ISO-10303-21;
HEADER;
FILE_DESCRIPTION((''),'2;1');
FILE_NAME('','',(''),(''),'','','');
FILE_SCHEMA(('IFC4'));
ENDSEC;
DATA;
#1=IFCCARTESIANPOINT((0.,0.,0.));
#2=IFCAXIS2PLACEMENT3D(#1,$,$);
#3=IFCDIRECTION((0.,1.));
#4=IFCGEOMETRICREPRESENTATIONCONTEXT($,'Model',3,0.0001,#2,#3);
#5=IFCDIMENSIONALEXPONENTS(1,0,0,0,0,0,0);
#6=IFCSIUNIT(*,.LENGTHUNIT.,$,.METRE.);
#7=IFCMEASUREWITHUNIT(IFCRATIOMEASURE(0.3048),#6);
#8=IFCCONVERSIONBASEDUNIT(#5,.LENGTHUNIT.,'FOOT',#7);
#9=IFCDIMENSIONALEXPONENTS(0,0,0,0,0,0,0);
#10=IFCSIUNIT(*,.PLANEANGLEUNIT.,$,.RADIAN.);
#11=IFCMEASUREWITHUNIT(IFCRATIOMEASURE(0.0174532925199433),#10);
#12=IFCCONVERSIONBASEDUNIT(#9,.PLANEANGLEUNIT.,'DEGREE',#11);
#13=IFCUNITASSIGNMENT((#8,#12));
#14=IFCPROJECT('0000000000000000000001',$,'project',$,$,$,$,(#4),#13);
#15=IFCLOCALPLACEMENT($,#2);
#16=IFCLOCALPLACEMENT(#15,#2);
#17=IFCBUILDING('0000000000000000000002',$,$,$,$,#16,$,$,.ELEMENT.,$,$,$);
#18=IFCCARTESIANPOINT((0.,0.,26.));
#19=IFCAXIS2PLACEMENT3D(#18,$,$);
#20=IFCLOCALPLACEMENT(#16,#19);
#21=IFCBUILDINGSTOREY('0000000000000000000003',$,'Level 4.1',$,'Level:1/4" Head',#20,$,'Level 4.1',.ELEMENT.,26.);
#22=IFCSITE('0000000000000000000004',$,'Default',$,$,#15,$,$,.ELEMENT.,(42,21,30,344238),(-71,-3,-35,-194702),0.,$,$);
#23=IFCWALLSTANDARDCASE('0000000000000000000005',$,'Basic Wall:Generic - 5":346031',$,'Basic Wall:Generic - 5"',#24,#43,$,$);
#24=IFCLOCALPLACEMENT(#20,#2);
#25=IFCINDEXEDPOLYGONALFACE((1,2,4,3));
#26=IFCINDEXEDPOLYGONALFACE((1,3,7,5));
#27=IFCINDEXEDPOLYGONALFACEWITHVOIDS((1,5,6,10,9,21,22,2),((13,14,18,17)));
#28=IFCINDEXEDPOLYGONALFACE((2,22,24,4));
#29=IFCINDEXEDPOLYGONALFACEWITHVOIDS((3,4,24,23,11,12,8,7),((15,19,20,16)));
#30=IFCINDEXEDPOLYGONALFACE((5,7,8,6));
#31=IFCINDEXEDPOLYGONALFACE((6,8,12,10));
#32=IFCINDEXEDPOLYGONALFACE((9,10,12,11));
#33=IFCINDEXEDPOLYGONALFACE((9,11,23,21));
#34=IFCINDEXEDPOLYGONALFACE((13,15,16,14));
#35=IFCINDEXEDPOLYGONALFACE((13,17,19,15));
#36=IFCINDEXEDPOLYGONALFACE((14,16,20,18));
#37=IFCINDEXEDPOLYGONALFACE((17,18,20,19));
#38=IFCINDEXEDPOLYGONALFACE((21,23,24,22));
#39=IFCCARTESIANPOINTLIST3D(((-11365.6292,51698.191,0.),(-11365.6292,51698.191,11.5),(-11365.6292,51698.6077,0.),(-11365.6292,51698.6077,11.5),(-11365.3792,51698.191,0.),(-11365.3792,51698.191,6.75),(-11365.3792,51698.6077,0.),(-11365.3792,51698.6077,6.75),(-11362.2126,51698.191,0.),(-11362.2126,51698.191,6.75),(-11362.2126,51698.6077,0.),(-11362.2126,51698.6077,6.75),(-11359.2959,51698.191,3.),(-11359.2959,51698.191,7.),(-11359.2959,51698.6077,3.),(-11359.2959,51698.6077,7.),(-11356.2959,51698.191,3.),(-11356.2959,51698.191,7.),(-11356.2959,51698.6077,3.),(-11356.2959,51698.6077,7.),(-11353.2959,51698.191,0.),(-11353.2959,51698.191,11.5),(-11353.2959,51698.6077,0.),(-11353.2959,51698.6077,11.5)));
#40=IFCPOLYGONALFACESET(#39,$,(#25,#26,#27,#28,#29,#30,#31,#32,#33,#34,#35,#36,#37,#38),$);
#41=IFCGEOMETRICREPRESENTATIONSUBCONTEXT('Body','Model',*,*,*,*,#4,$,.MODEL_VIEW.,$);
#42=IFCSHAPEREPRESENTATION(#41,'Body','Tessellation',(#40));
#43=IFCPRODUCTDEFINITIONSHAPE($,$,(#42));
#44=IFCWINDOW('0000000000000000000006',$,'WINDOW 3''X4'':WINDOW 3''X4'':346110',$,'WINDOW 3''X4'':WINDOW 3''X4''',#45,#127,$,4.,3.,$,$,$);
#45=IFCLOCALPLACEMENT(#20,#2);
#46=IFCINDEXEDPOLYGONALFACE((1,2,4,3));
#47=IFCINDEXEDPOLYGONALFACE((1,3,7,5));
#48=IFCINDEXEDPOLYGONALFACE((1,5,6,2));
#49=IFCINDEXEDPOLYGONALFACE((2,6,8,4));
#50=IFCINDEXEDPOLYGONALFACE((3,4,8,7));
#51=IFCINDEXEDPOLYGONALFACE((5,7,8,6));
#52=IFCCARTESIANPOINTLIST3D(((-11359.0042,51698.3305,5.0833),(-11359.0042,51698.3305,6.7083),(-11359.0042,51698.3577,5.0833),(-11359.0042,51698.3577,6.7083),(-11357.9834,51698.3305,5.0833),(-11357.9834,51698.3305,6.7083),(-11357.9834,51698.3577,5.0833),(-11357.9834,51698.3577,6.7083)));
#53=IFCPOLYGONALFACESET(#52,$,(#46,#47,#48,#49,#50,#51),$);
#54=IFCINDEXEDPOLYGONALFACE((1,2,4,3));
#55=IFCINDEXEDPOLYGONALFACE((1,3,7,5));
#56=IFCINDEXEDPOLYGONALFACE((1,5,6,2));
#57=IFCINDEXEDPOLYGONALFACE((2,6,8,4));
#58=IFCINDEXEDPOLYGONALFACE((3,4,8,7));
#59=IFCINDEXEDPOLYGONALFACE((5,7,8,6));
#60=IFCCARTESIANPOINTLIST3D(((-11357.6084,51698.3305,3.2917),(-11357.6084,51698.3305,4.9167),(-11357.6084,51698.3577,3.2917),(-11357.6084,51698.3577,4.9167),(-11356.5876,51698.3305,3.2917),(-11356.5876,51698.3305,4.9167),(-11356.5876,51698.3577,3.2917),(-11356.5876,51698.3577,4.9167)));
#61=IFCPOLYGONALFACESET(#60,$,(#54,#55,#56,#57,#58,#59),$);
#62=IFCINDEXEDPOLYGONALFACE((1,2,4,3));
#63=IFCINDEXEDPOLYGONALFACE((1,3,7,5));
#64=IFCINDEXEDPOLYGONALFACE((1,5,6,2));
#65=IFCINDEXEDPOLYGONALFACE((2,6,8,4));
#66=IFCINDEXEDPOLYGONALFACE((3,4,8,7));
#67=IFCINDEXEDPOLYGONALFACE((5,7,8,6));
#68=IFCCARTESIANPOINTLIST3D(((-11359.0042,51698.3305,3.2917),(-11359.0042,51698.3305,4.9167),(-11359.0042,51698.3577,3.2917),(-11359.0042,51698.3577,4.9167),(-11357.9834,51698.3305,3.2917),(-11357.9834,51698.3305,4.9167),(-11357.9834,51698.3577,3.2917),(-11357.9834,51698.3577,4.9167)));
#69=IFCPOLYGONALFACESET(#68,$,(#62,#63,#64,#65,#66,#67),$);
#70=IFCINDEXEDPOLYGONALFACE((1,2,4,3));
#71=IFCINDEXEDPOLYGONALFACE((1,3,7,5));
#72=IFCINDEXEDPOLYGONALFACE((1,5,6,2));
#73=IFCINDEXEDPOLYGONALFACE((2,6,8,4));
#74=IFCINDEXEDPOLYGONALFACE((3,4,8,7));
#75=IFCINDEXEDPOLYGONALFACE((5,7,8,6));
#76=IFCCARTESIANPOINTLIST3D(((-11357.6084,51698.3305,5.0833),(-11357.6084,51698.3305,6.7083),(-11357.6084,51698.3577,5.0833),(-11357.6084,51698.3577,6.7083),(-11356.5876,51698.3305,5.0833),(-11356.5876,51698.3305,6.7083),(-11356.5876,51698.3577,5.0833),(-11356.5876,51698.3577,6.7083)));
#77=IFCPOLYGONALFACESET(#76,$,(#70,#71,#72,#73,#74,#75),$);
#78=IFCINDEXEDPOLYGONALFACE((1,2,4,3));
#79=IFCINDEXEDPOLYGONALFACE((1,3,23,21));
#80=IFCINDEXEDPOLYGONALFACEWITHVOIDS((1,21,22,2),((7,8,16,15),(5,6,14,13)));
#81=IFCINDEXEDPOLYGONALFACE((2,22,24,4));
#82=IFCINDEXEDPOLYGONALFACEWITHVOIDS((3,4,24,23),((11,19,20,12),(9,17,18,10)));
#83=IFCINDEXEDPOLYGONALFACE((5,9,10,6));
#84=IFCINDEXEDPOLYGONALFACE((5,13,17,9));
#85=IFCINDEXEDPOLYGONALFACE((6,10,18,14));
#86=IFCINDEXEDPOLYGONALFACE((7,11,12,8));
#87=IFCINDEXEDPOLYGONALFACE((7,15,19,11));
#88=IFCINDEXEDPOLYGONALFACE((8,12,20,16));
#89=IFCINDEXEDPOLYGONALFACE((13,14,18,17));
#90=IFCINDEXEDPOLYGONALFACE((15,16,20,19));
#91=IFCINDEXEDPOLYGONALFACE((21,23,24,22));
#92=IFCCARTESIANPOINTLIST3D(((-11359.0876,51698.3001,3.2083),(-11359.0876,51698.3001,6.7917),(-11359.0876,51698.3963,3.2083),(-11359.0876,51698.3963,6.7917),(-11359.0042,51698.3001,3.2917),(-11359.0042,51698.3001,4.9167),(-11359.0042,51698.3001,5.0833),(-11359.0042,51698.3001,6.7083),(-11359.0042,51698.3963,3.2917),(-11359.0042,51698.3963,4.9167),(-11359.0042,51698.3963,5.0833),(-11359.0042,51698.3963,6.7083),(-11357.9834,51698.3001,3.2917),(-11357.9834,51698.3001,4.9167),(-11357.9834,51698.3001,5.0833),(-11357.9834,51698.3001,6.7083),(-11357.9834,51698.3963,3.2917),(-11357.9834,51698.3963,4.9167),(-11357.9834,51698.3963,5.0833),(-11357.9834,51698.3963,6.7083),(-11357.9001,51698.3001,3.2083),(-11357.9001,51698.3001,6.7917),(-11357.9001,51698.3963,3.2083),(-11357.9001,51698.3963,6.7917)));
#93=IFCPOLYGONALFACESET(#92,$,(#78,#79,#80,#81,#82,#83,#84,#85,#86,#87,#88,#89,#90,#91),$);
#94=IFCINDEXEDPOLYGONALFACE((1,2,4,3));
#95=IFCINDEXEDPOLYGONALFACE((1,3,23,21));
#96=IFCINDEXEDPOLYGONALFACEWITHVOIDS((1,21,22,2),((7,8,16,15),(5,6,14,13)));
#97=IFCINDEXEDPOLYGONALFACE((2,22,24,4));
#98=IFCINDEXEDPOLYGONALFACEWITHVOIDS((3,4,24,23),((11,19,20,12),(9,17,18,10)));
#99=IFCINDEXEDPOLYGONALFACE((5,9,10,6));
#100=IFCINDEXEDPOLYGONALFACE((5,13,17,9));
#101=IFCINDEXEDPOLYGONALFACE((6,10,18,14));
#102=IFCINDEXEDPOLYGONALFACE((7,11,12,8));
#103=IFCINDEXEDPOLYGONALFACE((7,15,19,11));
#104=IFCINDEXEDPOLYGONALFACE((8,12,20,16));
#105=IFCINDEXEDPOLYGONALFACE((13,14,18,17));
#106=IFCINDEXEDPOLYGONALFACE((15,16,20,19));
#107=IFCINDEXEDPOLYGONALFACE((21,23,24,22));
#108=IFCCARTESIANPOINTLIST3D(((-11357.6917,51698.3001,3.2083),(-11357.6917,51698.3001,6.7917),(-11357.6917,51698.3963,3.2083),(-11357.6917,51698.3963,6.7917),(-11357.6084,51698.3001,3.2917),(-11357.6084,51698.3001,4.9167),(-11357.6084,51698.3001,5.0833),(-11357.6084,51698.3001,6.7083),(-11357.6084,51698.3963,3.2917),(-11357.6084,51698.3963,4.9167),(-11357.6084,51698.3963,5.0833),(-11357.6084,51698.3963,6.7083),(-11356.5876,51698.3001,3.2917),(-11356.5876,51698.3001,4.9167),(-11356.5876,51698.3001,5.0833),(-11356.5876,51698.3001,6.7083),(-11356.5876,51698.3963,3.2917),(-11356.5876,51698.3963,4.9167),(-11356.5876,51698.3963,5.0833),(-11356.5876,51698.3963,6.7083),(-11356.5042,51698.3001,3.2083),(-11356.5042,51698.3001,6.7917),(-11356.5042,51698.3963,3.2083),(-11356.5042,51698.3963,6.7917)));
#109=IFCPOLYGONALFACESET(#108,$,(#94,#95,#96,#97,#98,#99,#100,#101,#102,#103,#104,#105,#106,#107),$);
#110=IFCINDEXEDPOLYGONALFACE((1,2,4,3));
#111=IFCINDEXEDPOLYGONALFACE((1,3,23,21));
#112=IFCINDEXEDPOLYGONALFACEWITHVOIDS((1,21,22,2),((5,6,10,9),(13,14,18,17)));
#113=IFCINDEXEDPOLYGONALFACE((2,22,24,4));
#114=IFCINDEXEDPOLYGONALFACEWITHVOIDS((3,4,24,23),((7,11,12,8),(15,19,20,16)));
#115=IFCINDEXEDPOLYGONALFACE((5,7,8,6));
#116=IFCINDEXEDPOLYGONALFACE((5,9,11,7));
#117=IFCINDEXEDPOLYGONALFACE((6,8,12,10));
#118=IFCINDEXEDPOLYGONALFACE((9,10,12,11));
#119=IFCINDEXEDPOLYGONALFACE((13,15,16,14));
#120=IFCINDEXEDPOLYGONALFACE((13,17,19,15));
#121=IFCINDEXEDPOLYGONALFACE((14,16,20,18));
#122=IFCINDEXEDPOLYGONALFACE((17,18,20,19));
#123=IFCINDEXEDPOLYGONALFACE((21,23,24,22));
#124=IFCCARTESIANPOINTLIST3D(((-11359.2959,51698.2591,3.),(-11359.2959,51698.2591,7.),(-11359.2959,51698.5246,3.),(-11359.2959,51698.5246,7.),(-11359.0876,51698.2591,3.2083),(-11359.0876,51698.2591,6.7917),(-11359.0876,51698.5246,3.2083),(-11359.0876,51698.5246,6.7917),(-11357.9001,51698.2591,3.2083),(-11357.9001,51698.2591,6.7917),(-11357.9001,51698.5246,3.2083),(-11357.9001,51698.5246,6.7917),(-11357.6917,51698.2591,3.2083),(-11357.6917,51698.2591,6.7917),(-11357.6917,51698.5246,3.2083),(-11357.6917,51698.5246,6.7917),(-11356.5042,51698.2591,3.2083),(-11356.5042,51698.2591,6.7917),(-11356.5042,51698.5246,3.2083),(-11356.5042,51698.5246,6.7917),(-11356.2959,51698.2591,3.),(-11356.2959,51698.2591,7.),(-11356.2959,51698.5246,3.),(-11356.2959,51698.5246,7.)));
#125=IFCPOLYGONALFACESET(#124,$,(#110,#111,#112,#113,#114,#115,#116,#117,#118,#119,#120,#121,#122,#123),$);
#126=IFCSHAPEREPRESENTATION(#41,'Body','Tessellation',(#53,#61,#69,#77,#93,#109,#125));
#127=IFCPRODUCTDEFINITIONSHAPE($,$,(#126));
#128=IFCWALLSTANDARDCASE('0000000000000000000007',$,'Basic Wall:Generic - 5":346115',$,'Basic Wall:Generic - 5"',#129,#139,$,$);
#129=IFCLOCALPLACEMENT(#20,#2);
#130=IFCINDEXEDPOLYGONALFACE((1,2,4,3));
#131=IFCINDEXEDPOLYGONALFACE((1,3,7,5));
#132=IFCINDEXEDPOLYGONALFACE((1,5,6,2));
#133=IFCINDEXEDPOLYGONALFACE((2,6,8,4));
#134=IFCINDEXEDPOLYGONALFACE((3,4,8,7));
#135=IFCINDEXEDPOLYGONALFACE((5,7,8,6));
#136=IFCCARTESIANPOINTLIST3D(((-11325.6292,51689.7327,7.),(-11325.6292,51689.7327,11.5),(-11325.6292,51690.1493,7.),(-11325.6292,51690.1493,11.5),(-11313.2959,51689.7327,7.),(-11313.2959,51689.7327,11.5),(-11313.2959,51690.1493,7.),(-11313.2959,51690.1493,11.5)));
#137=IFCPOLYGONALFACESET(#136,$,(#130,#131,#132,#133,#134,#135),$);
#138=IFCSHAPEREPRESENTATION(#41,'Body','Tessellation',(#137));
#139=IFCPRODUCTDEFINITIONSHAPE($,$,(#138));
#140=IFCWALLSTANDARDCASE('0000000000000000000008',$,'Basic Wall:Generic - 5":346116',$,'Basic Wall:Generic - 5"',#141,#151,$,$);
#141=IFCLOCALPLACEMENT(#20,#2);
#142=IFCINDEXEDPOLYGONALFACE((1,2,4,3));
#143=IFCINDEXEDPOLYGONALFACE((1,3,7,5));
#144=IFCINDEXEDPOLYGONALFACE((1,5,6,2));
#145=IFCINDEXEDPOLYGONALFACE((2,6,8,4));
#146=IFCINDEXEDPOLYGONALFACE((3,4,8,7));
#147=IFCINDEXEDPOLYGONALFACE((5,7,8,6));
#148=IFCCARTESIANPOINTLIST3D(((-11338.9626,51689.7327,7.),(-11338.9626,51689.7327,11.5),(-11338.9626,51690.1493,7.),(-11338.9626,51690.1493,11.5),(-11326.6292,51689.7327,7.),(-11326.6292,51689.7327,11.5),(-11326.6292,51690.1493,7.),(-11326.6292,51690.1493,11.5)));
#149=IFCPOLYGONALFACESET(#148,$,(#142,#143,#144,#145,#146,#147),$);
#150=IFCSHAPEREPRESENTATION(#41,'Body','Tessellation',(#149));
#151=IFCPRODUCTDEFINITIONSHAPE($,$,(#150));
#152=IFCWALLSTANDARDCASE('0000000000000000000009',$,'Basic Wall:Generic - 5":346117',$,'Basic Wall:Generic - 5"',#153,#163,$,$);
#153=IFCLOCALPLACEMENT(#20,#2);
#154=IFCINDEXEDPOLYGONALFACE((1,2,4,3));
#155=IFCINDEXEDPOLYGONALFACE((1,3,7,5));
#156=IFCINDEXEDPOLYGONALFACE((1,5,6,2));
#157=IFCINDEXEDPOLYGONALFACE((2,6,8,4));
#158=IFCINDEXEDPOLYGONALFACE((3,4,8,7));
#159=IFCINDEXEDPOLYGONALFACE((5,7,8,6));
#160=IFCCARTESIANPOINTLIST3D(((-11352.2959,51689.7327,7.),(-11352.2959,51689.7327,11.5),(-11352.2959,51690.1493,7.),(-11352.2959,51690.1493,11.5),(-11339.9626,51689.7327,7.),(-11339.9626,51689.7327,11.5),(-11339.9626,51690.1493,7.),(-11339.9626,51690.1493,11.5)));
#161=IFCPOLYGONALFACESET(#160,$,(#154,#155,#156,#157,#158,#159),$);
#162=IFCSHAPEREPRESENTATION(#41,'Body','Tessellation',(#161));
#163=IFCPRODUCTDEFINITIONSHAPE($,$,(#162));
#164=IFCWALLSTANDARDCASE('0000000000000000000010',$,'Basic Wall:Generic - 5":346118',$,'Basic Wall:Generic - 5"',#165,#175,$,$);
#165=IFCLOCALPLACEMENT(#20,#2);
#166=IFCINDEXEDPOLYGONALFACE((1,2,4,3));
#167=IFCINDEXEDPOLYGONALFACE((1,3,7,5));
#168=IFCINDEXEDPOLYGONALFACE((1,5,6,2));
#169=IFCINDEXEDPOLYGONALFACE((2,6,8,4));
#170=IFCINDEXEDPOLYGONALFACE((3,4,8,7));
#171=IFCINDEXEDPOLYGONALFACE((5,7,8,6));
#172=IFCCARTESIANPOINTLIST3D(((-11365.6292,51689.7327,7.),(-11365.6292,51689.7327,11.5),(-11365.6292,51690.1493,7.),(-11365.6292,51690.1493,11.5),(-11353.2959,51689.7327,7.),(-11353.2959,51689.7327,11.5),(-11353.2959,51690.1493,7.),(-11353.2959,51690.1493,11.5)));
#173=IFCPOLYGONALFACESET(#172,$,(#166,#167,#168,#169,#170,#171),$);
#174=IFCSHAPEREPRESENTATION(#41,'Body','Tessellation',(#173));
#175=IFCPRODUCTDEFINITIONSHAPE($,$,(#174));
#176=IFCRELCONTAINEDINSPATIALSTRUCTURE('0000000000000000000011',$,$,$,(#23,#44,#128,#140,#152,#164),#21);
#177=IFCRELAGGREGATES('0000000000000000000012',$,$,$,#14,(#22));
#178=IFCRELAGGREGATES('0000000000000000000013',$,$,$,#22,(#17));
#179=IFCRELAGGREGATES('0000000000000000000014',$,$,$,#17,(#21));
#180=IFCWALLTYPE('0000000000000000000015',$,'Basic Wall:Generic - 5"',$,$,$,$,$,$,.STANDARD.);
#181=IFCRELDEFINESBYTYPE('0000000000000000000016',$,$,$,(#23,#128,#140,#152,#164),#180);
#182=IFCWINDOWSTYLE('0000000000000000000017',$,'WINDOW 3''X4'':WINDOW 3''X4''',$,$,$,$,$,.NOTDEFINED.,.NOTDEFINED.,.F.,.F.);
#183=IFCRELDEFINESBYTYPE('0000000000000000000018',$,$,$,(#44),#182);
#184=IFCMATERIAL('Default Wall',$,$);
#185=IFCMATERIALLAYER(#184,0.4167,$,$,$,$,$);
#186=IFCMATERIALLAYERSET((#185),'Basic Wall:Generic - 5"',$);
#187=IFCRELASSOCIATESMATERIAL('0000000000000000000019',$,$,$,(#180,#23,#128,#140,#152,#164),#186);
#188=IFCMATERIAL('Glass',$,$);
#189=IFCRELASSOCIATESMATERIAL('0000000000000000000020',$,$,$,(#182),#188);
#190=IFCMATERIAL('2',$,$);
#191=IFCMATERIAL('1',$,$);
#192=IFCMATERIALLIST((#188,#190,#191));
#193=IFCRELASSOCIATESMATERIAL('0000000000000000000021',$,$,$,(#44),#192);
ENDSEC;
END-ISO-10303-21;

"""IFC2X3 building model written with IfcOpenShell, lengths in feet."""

from ifc_helpers import new_model, entity, si_unit, converted_unit, direction, frame, frame_2d, origin, origin_2d_with_axis, place, context, subcontext, project, spatial, polyline, rectangle, outline, extrude, source, transform, mapped, material, material_list, layer, layer_set, layer_usage, type_object, type_shapes, element, fill, save


model = new_model("IFC2X3")

# Units and contexts
model_context = context("Model", 3, precision=0.0001, world=origin(), true_north=direction((0.0, 1.0)))
body_context = subcontext(model_context, "Body", "Model", "MODEL_VIEW")
ifc_project = project(units=[converted_unit("LENGTHUNIT", "FOOT", entity("IfcRatioMeasure", 0.3048), si_unit("LENGTHUNIT", "METRE"), dimensions=[1, 0, 0, 0, 0, 0, 0]), converted_unit("PLANEANGLEUNIT", "DEGREE", entity("IfcRatioMeasure", 0.0174532925199433), si_unit("PLANEANGLEUNIT", "RADIAN"), dimensions=[0, 0, 0, 0, 0, 0, 0])], contexts=[model_context])

# Site, building, storey
site_placement = place(None, origin())
site = spatial("IfcSite", under=ifc_project, at=site_placement, Name="Default", CompositionType="ELEMENT", RefLatitude=(42, 21, 30, 344238), RefLongitude=(-71, -3, -35, -194702), RefElevation=0.0)
building_placement = place(site_placement, origin())
building = spatial("IfcBuilding", under=site, at=building_placement, CompositionType="ELEMENT")
storey_placement = place(building_placement, frame((0.0, 0.0, 26.0)))
storey = spatial("IfcBuildingStorey", under=building, at=storey_placement, Name="Level 4.1", ObjectType="Level:1/4\" Head", LongName="Level 4.1", CompositionType="ELEMENT", Elevation=26.0)

# Wall, openings, window
ifc_material_1 = material(Name="Default Wall")
ifc_layer = layer(ifc_material_1, 0.4167)
ifc_layer_set = layer_set([ifc_layer], Name="Basic Wall:Generic - 5\"")
ifc_layer_usage_1 = layer_usage(ifc_layer_set, "AXIS2", "NEGATIVE", 0.2083)
wall_type = type_object("IfcWallType", Name="Basic Wall:Generic - 5\"", PredefinedType="STANDARD", material=ifc_layer_set)
wall_1_placement = place(storey_placement, frame((-11365.6292, 51698.3993, 0.0)))
wall_1 = element("IfcWallStandardCase", 1, at=wall_1_placement, inside=storey, type_object=wall_type, material=ifc_layer_usage_1, Name="Basic Wall:Generic - 5\":346031", ObjectType="Basic Wall:Generic - 5\"", context=body_context, shape_type="SweptSolid", body=[
    extrude(rectangle(XDim=12.3333, YDim=0.4167, at=frame_2d((6.1667, 0.0), x_axis=(-1.0, 0.0))), origin(), (0.0, 0.0, 1.0), 11.5),
])
opening_1_placement = place(wall_1_placement, frame((0.25, -0.2083, 0.0)))
element("IfcOpeningElement", 2, at=opening_1_placement, cuts=wall_1, ObjectType="Opening", context=body_context, shape_type="SweptSolid", body=[
    extrude(rectangle(XDim=6.75, YDim=3.1667, at=frame_2d((3.375, 1.5833), x_axis=(1.0, 0.0))), frame((0.0, 0.0, 0.0), z_axis=(0.0, 1.0, 0.0), x_axis=(0.0, 0.0, 1.0)), (0.0, 0.0, 1.0), 0.4167),
])
opening_2_placement = place(wall_1_placement, frame((9.3333, 0.2083, 3.0)))
opening_2 = element("IfcOpeningElement", 3, at=opening_2_placement, cuts=wall_1, ObjectType="Opening", context=body_context, shape_type="SweptSolid", body=[
    extrude(rectangle(XDim=4.0, YDim=3.0, at=frame_2d((2.0, 1.5), x_axis=(-1.0, 0.0))), frame((0.0, 0.0, 0.0), z_axis=(0.0, -1.0, 0.0), x_axis=(0.0, 0.0, 1.0)), (0.0, 0.0, 1.0), 0.4167),
])
ifc_material_2 = material(Name="Glass")
ifc_material_3 = material(Name="2")
ifc_material_4 = material(Name="1")
ifc_material_list = material_list([ifc_material_2, ifc_material_3, ifc_material_4])
window_style = type_object("IfcWindowStyle", Name="WINDOW 3'X4':WINDOW 3'X4'", ConstructionType="NOTDEFINED", OperationType="NOTDEFINED", ParameterTakesPrecedence=False, Sizeable=False, material=ifc_material_2)
shared_shape = source(origin(), body_context, "Body", "SweptSolid", [
    extrude(rectangle(XDim=0.0272, YDim=1.0208, at=origin_2d_with_axis()), frame((2.1979, 0.2636, 2.0833), z_axis=(0.0, 0.0, 1.0), x_axis=(0.0, 1.0, 0.0)), (0.0, 0.0, 1.0), 1.625),
    extrude(rectangle(XDim=0.0272, YDim=1.0208, at=origin_2d_with_axis()), frame((0.8021, 0.2636, 0.2917), z_axis=(0.0, 0.0, 1.0), x_axis=(0.0, 1.0, 0.0)), (0.0, 0.0, 1.0), 1.625),
    extrude(rectangle(XDim=0.0272, YDim=1.0208, at=origin_2d_with_axis()), frame((2.1979, 0.2636, 0.2917), z_axis=(0.0, 0.0, 1.0), x_axis=(0.0, 1.0, 0.0)), (0.0, 0.0, 1.0), 1.625),
    extrude(rectangle(XDim=0.0272, YDim=1.0208, at=origin_2d_with_axis()), frame((0.8021, 0.2636, 2.0833), z_axis=(0.0, 0.0, 1.0), x_axis=(0.0, 1.0, 0.0)), (0.0, 0.0, 1.0), 1.625),
    extrude(outline(polyline([(-0.5938, -1.7917), (0.5938, -1.7917), (0.5938, 1.7917), (-0.5938, 1.7917), (-0.5938, -1.7917)]), holes=[polyline([(-0.5104, -0.0833), (0.5104, -0.0833), (0.5104, -1.7083), (-0.5104, -1.7083), (-0.5104, -0.0833)]), polyline([(-0.5104, 1.7083), (0.5104, 1.7083), (0.5104, 0.0833), (-0.5104, 0.0833), (-0.5104, 1.7083)])]), frame((2.1979, 0.2114, 2.0), z_axis=(0.0, 1.0, 0.0), x_axis=(-1.0, 0.0, 0.0)), (0.0, 0.0, 1.0), 0.0962),
    extrude(outline(polyline([(-1.7917, -0.5937), (1.7917, -0.5937), (1.7917, 0.5937), (-1.7917, 0.5937), (-1.7917, -0.5937)]), holes=[polyline([(0.0833, -0.5104), (0.0833, 0.5104), (1.7083, 0.5104), (1.7083, -0.5104), (0.0833, -0.5104)]), polyline([(-1.7083, -0.5104), (-1.7083, 0.5104), (-0.0833, 0.5104), (-0.0833, -0.5104), (-1.7083, -0.5104)])]), frame((0.8021, 0.2114, 2.0), z_axis=(0.0, 1.0, 0.0), x_axis=(0.0, 0.0, -1.0)), (0.0, 0.0, 1.0), 0.0962),
    extrude(outline(polyline([(-1.5, -2.0), (1.5, -2.0), (1.5, 2.0), (-1.5, 2.0), (-1.5, -2.0)]), holes=[polyline([(-0.1042, 1.7917), (-0.1042, -1.7917), (-1.2917, -1.7917), (-1.2917, 1.7917), (-0.1042, 1.7917)]), polyline([(0.1042, -1.7917), (0.1042, 1.7917), (1.2917, 1.7917), (1.2917, -1.7917), (0.1042, -1.7917)])]), frame((1.5, 0.0831, 2.0), z_axis=(0.0, 1.0, 0.0), x_axis=(1.0, 0.0, 0.0)), (0.0, 0.0, 1.0), 0.2655),
])
type_shapes(window_style, [shared_shape])
window_placement = place(opening_2_placement, frame((0.0, 0.0, 0.0), z_axis=(0.0, 0.0, 1.0), x_axis=(-1.0, 0.0, 0.0)))
window = element("IfcWindow", 4, at=window_placement, inside=storey, type_object=window_style, material=ifc_material_list, Name="WINDOW 3'X4':WINDOW 3'X4':346110", ObjectType="WINDOW 3'X4':WINDOW 3'X4'", OverallHeight=4.0, OverallWidth=3.0, context=body_context, shape_type="MappedRepresentation", body=[
    mapped(shared_shape, transform((0.0, 0.0, 0.0), scale=1.0)),
])
fill(opening_2, window)

# Walls
ifc_layer_usage_2 = layer_usage(ifc_layer_set, "AXIS2", "NEGATIVE", 0.2083)
wall_2_placement = place(storey_placement, frame((-11313.2959, 51689.941, 7.0), z_axis=(0.0, 0.0, 1.0), x_axis=(-1.0, 0.0, 0.0)))
element("IfcWallStandardCase", 5, at=wall_2_placement, inside=storey, type_object=wall_type, material=ifc_layer_usage_2, Name="Basic Wall:Generic - 5\":346115", ObjectType="Basic Wall:Generic - 5\"", context=body_context, shape_type="SweptSolid", body=[
    extrude(rectangle(XDim=12.3333, YDim=0.4167, at=frame_2d((6.1667, 0.0), x_axis=(-1.0, 0.0))), origin(), (0.0, 0.0, 1.0), 4.5),
])
ifc_layer_usage_3 = layer_usage(ifc_layer_set, "AXIS2", "NEGATIVE", 0.2083)
wall_3_placement = place(storey_placement, frame((-11326.6292, 51689.941, 7.0), z_axis=(0.0, 0.0, 1.0), x_axis=(-1.0, 0.0, 0.0)))
element("IfcWallStandardCase", 6, at=wall_3_placement, inside=storey, type_object=wall_type, material=ifc_layer_usage_3, Name="Basic Wall:Generic - 5\":346116", ObjectType="Basic Wall:Generic - 5\"", context=body_context, shape_type="SweptSolid", body=[
    extrude(rectangle(XDim=12.3333, YDim=0.4167, at=frame_2d((6.1667, 0.0), x_axis=(-1.0, 0.0))), origin(), (0.0, 0.0, 1.0), 4.5),
])
ifc_layer_usage_4 = layer_usage(ifc_layer_set, "AXIS2", "NEGATIVE", 0.2083)
wall_4_placement = place(storey_placement, frame((-11339.9626, 51689.941, 7.0), z_axis=(0.0, 0.0, 1.0), x_axis=(-1.0, 0.0, 0.0)))
element("IfcWallStandardCase", 7, at=wall_4_placement, inside=storey, type_object=wall_type, material=ifc_layer_usage_4, Name="Basic Wall:Generic - 5\":346117", ObjectType="Basic Wall:Generic - 5\"", context=body_context, shape_type="SweptSolid", body=[
    extrude(rectangle(XDim=12.3333, YDim=0.4167, at=frame_2d((6.1667, 0.0), x_axis=(-1.0, 0.0))), origin(), (0.0, 0.0, 1.0), 4.5),
])
ifc_layer_usage_5 = layer_usage(ifc_layer_set, "AXIS2", "NEGATIVE", 0.2083)
wall_5_placement = place(storey_placement, frame((-11353.2959, 51689.941, 7.0), z_axis=(0.0, 0.0, 1.0), x_axis=(-1.0, 0.0, 0.0)))
element("IfcWallStandardCase", 8, at=wall_5_placement, inside=storey, type_object=wall_type, material=ifc_layer_usage_5, Name="Basic Wall:Generic - 5\":346118", ObjectType="Basic Wall:Generic - 5\"", context=body_context, shape_type="SweptSolid", body=[
    extrude(rectangle(XDim=12.3333, YDim=0.4167, at=frame_2d((6.1667, 0.0), x_axis=(-1.0, 0.0))), origin(), (0.0, 0.0, 1.0), 4.5),
])

save(model, "model.ifc")
